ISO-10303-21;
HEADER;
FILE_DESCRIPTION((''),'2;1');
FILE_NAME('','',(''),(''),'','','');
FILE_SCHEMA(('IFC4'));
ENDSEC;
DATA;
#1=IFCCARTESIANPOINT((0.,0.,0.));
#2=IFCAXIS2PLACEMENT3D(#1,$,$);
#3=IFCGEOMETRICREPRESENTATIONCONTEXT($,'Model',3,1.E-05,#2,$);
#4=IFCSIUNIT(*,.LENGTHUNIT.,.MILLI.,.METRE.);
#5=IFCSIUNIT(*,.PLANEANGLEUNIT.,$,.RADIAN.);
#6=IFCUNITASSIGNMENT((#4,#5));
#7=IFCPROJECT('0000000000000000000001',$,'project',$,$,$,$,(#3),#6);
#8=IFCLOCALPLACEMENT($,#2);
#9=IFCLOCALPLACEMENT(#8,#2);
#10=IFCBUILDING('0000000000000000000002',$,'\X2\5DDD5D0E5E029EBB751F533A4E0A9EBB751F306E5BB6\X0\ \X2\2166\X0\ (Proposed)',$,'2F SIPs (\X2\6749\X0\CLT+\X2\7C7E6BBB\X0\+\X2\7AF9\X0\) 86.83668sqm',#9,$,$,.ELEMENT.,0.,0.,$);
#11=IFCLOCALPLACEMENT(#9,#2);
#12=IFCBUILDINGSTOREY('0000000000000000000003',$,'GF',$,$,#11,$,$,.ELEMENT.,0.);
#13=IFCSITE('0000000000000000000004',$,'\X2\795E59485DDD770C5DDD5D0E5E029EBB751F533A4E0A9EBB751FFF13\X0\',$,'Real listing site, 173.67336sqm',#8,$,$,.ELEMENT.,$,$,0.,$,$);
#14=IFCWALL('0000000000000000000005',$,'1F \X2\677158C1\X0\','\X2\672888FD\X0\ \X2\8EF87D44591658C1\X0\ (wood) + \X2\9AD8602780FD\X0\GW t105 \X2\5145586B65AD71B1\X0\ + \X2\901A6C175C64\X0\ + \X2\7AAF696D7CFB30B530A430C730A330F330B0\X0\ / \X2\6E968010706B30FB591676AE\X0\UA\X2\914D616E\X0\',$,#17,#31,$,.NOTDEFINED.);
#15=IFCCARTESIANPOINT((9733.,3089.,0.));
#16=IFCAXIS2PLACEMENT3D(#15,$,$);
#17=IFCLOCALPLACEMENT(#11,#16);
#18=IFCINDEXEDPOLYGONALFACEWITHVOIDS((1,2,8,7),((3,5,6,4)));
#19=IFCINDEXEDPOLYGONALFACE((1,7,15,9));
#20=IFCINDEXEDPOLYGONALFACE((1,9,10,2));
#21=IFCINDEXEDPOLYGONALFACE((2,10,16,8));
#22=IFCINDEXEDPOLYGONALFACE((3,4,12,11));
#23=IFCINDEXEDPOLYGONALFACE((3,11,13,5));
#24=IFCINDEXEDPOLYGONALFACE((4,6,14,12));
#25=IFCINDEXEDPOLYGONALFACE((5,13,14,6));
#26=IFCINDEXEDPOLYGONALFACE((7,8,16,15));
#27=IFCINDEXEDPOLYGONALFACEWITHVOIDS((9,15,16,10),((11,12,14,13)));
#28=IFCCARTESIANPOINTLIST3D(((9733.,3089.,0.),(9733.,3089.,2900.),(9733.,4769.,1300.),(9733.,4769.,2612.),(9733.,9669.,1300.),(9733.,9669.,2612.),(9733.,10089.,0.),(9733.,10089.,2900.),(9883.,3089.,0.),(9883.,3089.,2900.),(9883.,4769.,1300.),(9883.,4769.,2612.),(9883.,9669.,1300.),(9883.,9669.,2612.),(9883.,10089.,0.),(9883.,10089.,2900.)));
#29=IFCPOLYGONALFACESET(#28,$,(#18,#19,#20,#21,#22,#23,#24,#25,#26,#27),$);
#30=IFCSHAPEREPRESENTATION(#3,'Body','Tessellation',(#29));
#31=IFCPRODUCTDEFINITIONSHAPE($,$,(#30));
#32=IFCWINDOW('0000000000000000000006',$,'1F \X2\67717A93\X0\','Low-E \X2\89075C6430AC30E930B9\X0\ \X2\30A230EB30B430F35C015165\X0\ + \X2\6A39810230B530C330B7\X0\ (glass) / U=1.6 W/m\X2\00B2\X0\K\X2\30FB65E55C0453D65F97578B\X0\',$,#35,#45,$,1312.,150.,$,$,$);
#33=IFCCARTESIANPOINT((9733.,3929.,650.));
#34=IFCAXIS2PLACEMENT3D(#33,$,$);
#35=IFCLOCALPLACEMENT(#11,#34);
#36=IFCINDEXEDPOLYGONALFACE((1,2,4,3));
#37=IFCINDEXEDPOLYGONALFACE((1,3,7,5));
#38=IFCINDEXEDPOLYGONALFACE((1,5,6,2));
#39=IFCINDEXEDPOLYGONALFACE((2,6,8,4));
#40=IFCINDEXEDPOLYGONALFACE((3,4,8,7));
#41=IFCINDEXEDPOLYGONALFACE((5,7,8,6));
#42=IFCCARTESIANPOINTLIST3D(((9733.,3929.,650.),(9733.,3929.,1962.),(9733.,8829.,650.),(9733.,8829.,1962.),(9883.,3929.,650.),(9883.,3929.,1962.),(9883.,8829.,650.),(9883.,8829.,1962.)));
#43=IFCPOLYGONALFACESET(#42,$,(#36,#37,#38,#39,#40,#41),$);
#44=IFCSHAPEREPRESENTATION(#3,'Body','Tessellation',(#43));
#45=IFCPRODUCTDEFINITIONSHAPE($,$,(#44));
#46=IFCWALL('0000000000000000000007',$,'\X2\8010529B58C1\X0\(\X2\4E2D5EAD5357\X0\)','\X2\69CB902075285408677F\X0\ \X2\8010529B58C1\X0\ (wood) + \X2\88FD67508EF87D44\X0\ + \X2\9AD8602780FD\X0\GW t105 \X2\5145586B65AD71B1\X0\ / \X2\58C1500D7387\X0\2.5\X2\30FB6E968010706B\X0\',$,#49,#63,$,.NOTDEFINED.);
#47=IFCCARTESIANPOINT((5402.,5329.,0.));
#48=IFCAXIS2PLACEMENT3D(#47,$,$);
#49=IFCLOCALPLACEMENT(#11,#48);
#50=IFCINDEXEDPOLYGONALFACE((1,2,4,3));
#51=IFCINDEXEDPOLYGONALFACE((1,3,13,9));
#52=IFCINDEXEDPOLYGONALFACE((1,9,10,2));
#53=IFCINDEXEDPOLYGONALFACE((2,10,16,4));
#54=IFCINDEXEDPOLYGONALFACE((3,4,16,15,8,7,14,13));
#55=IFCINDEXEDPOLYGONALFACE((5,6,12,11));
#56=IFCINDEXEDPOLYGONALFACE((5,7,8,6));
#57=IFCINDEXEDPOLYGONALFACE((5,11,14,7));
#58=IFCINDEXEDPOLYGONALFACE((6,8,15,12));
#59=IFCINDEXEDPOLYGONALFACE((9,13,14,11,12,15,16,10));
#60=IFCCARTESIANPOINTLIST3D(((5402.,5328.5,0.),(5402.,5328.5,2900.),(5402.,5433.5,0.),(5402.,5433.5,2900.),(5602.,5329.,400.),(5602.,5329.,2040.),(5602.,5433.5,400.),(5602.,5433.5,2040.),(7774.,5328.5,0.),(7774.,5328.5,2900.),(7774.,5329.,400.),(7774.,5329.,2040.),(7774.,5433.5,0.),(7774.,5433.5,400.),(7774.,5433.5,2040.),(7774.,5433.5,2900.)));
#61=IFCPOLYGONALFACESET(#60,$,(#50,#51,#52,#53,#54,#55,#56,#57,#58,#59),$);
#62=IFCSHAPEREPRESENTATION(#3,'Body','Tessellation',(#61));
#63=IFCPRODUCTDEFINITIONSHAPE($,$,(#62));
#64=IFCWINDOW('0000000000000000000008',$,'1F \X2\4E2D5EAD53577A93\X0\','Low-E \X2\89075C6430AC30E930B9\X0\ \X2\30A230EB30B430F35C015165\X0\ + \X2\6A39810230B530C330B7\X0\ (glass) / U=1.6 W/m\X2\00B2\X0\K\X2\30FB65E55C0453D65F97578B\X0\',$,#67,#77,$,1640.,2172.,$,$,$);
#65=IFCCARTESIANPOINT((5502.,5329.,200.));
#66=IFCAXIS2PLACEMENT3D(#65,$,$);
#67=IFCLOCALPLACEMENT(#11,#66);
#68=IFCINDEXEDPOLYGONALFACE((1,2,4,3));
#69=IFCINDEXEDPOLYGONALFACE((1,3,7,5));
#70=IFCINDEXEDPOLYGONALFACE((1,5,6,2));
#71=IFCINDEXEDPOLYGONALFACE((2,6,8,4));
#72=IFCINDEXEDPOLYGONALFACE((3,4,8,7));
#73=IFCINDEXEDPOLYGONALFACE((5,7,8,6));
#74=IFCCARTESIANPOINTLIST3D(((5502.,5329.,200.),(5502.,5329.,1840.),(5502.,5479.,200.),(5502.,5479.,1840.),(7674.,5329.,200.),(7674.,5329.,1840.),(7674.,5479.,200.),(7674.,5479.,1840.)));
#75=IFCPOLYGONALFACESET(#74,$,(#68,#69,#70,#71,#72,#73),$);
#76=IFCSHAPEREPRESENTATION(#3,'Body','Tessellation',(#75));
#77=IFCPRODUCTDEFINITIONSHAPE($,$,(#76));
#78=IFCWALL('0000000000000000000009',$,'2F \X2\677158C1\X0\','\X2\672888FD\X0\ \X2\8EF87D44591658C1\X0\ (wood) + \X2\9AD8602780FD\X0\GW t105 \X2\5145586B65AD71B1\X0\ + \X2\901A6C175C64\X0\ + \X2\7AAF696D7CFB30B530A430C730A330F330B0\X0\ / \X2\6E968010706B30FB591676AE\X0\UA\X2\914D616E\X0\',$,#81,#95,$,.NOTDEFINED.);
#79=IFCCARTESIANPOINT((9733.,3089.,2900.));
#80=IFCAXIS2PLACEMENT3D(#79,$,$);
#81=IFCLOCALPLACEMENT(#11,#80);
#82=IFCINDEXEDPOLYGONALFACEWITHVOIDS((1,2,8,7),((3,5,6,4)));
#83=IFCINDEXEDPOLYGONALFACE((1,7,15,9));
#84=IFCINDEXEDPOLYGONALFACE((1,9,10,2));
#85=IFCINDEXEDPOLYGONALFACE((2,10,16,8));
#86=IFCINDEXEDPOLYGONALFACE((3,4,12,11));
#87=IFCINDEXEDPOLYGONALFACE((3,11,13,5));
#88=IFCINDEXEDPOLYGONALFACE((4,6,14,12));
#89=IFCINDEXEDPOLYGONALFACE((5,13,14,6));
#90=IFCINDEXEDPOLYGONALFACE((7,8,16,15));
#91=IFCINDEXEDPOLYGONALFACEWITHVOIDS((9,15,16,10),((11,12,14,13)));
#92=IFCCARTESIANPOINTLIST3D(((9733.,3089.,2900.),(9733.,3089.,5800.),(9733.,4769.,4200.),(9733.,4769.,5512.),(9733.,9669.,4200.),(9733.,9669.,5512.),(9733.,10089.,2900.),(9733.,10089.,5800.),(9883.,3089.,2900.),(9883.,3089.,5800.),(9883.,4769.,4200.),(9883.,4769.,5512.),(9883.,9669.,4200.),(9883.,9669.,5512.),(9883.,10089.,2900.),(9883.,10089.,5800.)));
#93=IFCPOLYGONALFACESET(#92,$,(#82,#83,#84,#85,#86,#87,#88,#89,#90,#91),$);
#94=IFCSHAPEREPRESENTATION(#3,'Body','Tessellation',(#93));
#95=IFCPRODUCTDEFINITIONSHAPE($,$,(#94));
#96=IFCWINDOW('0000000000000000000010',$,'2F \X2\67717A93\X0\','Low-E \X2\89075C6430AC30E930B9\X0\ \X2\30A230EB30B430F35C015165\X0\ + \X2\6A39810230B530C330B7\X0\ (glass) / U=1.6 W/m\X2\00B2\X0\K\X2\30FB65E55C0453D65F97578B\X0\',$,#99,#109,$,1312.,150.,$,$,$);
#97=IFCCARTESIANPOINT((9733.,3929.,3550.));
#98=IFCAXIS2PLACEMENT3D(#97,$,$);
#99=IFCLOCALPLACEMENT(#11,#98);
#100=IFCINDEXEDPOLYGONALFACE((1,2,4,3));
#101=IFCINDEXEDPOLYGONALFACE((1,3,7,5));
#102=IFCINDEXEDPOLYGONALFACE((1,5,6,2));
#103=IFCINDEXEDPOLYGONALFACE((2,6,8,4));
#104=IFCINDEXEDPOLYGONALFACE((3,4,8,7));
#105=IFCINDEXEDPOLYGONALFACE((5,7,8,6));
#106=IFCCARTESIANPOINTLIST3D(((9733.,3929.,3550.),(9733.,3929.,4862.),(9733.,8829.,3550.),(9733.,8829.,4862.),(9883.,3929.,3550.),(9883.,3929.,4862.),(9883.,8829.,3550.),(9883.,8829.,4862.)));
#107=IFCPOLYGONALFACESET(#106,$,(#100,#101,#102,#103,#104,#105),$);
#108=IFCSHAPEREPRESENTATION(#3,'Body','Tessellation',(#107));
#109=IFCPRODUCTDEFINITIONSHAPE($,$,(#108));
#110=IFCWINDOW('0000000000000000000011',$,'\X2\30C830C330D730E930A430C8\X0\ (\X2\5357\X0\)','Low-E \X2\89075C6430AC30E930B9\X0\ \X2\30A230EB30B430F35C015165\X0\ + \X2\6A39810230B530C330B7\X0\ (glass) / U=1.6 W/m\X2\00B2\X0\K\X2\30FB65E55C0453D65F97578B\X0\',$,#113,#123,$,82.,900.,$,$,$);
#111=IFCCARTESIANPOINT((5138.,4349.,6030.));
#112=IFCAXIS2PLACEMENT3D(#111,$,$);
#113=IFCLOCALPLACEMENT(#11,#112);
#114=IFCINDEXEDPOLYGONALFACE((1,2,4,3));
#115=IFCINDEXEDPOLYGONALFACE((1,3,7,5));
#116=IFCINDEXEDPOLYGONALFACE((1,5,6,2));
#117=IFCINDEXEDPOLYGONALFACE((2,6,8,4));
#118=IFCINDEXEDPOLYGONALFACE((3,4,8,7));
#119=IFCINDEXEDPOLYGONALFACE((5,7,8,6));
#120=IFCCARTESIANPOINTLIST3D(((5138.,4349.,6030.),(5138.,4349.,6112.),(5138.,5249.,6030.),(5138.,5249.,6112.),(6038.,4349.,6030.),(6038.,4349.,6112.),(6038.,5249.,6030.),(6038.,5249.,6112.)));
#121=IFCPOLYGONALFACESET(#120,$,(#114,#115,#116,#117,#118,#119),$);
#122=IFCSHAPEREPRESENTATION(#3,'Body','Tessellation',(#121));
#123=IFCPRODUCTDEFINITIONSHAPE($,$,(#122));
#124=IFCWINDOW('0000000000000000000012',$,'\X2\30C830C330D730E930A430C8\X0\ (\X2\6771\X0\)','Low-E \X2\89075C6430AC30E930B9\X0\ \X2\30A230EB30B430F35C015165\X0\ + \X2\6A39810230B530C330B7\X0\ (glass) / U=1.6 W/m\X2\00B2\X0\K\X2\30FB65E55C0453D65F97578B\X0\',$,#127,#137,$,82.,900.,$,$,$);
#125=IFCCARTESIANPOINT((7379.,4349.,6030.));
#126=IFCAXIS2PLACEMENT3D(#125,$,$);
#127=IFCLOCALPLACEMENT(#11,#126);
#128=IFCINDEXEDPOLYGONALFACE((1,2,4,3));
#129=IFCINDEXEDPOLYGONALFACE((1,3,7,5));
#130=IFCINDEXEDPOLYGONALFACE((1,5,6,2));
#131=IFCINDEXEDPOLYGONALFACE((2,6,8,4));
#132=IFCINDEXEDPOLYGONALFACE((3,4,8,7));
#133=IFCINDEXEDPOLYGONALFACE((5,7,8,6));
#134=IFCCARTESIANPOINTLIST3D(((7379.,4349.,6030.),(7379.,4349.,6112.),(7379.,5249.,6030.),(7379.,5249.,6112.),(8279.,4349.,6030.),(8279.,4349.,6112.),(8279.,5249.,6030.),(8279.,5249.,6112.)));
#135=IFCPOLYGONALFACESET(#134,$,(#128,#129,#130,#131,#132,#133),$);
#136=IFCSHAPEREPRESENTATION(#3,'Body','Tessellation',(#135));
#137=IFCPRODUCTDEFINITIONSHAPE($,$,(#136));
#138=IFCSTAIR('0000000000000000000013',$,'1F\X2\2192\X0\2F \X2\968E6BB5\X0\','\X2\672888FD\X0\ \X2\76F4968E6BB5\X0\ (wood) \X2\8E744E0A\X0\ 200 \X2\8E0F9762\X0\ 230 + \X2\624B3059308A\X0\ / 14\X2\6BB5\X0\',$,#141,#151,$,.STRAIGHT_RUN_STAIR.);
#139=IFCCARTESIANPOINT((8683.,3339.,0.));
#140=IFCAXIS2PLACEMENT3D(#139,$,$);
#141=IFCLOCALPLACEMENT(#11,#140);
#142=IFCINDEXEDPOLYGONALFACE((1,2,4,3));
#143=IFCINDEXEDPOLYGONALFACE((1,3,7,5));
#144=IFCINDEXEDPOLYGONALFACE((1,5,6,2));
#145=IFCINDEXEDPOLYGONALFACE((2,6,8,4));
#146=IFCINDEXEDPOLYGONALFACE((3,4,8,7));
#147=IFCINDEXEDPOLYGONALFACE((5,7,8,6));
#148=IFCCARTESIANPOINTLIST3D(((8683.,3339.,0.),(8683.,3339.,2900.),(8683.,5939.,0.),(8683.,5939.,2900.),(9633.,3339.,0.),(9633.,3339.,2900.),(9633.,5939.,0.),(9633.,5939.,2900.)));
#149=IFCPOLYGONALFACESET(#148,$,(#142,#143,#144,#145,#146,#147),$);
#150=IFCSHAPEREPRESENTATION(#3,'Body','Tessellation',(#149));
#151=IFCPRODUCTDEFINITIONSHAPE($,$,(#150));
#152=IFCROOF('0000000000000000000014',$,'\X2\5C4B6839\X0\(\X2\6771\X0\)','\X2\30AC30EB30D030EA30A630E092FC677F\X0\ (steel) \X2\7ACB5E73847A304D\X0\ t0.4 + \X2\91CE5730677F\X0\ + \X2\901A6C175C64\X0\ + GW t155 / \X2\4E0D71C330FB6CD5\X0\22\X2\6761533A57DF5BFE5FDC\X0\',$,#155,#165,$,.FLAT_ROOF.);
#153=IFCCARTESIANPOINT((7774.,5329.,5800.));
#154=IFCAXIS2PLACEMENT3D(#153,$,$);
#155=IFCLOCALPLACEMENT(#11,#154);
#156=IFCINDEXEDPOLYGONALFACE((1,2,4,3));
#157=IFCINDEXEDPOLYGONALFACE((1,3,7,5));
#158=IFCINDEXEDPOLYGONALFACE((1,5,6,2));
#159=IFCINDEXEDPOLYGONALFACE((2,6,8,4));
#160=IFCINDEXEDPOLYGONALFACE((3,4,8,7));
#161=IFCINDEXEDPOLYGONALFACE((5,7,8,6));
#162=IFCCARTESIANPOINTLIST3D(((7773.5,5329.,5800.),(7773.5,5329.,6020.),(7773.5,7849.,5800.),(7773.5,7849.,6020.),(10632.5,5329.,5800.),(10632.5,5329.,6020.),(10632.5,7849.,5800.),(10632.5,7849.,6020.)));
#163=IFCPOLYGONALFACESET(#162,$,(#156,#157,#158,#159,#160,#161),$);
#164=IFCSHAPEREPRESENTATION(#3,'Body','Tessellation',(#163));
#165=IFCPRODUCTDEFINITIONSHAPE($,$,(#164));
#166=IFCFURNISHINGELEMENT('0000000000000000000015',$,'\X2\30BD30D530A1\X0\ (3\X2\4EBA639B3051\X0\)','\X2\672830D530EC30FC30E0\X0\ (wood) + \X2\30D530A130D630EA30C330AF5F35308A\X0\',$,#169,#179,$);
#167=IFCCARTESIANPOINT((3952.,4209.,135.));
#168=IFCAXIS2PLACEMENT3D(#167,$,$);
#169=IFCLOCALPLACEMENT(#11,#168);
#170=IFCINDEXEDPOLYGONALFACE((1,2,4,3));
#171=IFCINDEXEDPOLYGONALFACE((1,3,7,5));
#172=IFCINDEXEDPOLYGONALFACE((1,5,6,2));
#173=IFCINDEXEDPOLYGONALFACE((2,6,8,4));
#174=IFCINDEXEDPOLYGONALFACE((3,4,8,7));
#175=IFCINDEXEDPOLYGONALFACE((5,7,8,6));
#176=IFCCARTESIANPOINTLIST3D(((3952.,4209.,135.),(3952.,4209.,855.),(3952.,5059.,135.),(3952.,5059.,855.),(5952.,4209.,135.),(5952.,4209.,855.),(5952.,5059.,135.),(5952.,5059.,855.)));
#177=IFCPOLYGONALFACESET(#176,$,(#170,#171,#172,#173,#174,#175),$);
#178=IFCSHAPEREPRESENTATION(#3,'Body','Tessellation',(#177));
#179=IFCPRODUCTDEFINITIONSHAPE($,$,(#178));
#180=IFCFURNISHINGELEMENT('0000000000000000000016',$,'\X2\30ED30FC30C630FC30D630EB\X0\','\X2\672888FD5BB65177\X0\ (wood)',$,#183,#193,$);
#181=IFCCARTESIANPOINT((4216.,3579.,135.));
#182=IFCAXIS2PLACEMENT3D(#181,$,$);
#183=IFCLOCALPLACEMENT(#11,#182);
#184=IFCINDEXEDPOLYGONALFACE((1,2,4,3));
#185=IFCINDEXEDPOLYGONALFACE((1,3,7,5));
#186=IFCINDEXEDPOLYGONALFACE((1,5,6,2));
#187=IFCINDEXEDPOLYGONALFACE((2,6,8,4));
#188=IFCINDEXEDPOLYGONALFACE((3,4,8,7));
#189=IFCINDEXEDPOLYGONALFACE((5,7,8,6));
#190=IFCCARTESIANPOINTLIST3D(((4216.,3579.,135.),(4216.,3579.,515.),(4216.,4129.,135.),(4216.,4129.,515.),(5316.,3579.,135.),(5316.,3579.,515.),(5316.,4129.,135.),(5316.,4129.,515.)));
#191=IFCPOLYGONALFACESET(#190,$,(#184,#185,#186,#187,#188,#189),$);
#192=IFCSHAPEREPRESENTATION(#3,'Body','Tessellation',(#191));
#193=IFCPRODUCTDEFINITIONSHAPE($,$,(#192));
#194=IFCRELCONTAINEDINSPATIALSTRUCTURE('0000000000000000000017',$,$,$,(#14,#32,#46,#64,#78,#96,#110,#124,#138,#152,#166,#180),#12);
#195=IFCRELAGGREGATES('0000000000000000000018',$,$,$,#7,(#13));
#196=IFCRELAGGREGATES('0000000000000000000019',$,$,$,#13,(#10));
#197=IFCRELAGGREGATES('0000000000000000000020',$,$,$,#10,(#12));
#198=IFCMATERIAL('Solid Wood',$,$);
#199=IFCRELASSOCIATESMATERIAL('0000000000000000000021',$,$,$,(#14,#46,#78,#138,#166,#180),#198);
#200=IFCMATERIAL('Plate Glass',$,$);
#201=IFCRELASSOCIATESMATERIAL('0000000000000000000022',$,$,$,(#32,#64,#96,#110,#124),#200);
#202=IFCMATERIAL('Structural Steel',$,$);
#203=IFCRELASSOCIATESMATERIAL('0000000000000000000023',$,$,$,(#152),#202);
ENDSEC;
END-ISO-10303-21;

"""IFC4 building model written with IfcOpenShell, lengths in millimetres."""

from ifc_helpers import new_model, si_unit, frame, frame_2d, origin, place, context, project, spatial, rectangle, extrude, material, element, fill, save


model = new_model("IFC4")

# Units and contexts
model_context = context("Model", 3, precision=1e-05, world=origin())
ifc_project = project(units=[si_unit("LENGTHUNIT", "METRE", prefix="MILLI"), si_unit("PLANEANGLEUNIT", "RADIAN")], contexts=[model_context])

# Site, building, storey
site_placement = place(None, origin())
site = spatial("IfcSite", under=ifc_project, at=site_placement, Name="神奈川県川崎市麻生区上麻生３", ObjectType="Real listing site, 173.67336sqm", CompositionType="ELEMENT", RefElevation=0.0)
building_placement = place(site_placement, origin())
building = spatial("IfcBuilding", under=site, at=building_placement, Name="川崎市麻生区上麻生の家 Ⅶ (Proposed)", ObjectType="2F SIPs (杉CLT+籾殻+竹) 86.83668sqm", CompositionType="ELEMENT", ElevationOfRefHeight=0.0, ElevationOfTerrain=0.0)
storey_placement = place(building_placement, origin())
storey = spatial("IfcBuildingStorey", under=building, at=storey_placement, Name="GF", CompositionType="ELEMENT", Elevation=0.0)

# Shared definitions
ifc_material_1 = material(Name="Solid Wood")

# Walls, openings, windows
wall_1_placement = place(storey_placement, frame((9733.0, 3089.0, 0.0)))
wall_1 = element("IfcWall", 1, at=wall_1_placement, inside=storey, material=ifc_material_1, Name="1F 東壁", Description="木製 軸組外壁 (wood) + 高性能GW t105 充填断熱 + 通気層 + 窯業系サイディング / 準耐火・外皮UA配慮", PredefinedType="NOTDEFINED", context=model_context, shape_type="SweptSolid", body=[
    extrude(rectangle(XDim=150.0, YDim=7000.0, at=frame_2d((75.0, 3500.0))), frame((9733.0, 3089.0, 0.0)), (0.0, 0.0, 1.0), 2900.0),
])
opening_1_placement = place(storey_placement, frame((9733.0, 3929.0, 650.0)))
opening_1 = element("IfcOpeningElement", 2, at=opening_1_placement, cuts=wall_1, PredefinedType="NOTDEFINED", context=model_context, shape_type="SweptSolid", body=[
    extrude(rectangle(XDim=150.0, YDim=4900.0, at=frame_2d((75.0, 2450.0))), frame((9733.0, 3929.0, 650.0)), (0.0, 0.0, 1.0), 1312.0),
])
ifc_material_2 = material(Name="Plate Glass")
window_1_placement = place(storey_placement, frame((9733.0, 3929.0, 650.0)))
window_1 = element("IfcWindow", 3, at=window_1_placement, inside=storey, material=ifc_material_2, Name="1F 東窓", Description="Low-E 複層ガラス アルゴン封入 + 樹脂サッシ (glass) / U=1.6 W/m²K・日射取得型", OverallHeight=1312.0, OverallWidth=150.0, context=model_context, shape_type="SweptSolid", body=[
    extrude(rectangle(XDim=150.0, YDim=4900.0, at=frame_2d((75.0, 2450.0))), frame((9733.0, 3929.0, 650.0)), (0.0, 0.0, 1.0), 1312.0),
])
fill(opening_1, window_1)
wall_2_placement = place(storey_placement, frame((5402.0, 5329.0, 0.0)))
wall_2 = element("IfcWall", 4, at=wall_2_placement, inside=storey, material=ifc_material_1, Name="耐力壁(中庭南)", Description="構造用合板 耐力壁 (wood) + 製材軸組 + 高性能GW t105 充填断熱 / 壁倍率2.5・準耐火", PredefinedType="NOTDEFINED", context=model_context, shape_type="SweptSolid", body=[
    extrude(rectangle(XDim=2372.0, YDim=105.0, at=frame_2d((1186.0, 52.0))), frame((5402.0, 5329.0, 0.0)), (0.0, 0.0, 1.0), 2900.0),
])
opening_2_placement = place(storey_placement, frame((5502.0, 5329.0, 200.0)))
opening_2 = element("IfcOpeningElement", 5, at=opening_2_placement, cuts=wall_2, PredefinedType="NOTDEFINED", context=model_context, shape_type="SweptSolid", body=[
    extrude(rectangle(XDim=2172.0, YDim=150.0, at=frame_2d((1086.0, 75.0))), frame((5502.0, 5329.0, 200.0)), (0.0, 0.0, 1.0), 1640.0),
])
window_2_placement = place(storey_placement, frame((5502.0, 5329.0, 200.0)))
window_2 = element("IfcWindow", 6, at=window_2_placement, inside=storey, material=ifc_material_2, Name="1F 中庭南窓", Description="Low-E 複層ガラス アルゴン封入 + 樹脂サッシ (glass) / U=1.6 W/m²K・日射取得型", OverallHeight=1640.0, OverallWidth=2172.0, context=model_context, shape_type="SweptSolid", body=[
    extrude(rectangle(XDim=2172.0, YDim=150.0, at=frame_2d((1086.0, 75.0))), frame((5502.0, 5329.0, 200.0)), (0.0, 0.0, 1.0), 1640.0),
])
fill(opening_2, window_2)

# Wall, opening, window
wall_3_placement = place(storey_placement, frame((9733.0, 3089.0, 2900.0)))
wall_3 = element("IfcWall", 7, at=wall_3_placement, inside=storey, material=ifc_material_1, Name="2F 東壁", Description="木製 軸組外壁 (wood) + 高性能GW t105 充填断熱 + 通気層 + 窯業系サイディング / 準耐火・外皮UA配慮", PredefinedType="NOTDEFINED", context=model_context, shape_type="SweptSolid", body=[
    extrude(rectangle(XDim=150.0, YDim=7000.0, at=frame_2d((75.0, 3500.0))), frame((9733.0, 3089.0, 2900.0)), (0.0, 0.0, 1.0), 2900.0),
])
opening_3_placement = place(storey_placement, frame((9733.0, 3929.0, 3550.0)))
opening_3 = element("IfcOpeningElement", 8, at=opening_3_placement, cuts=wall_3, PredefinedType="NOTDEFINED", context=model_context, shape_type="SweptSolid", body=[
    extrude(rectangle(XDim=150.0, YDim=4900.0, at=frame_2d((75.0, 2450.0))), frame((9733.0, 3929.0, 3550.0)), (0.0, 0.0, 1.0), 1312.0),
])
window_3_placement = place(storey_placement, frame((9733.0, 3929.0, 3550.0)))
window_3 = element("IfcWindow", 9, at=window_3_placement, inside=storey, material=ifc_material_2, Name="2F 東窓", Description="Low-E 複層ガラス アルゴン封入 + 樹脂サッシ (glass) / U=1.6 W/m²K・日射取得型", OverallHeight=1312.0, OverallWidth=150.0, context=model_context, shape_type="SweptSolid", body=[
    extrude(rectangle(XDim=150.0, YDim=4900.0, at=frame_2d((75.0, 2450.0))), frame((9733.0, 3929.0, 3550.0)), (0.0, 0.0, 1.0), 1312.0),
])
fill(opening_3, window_3)

# Windows
window_4_placement = place(storey_placement, frame((5138.0, 4349.0, 6030.0)))
element("IfcWindow", 10, at=window_4_placement, inside=storey, material=ifc_material_2, Name="トップライト (南)", Description="Low-E 複層ガラス アルゴン封入 + 樹脂サッシ (glass) / U=1.6 W/m²K・日射取得型", OverallHeight=82.0, OverallWidth=900.0, context=model_context, shape_type="SweptSolid", body=[
    extrude(rectangle(XDim=900.0, YDim=900.0, at=frame_2d((450.0, 450.0))), frame((5138.0, 4349.0, 6030.0)), (0.0, 0.0, 1.0), 82.0),
])
window_5_placement = place(storey_placement, frame((7379.0, 4349.0, 6030.0)))
element("IfcWindow", 11, at=window_5_placement, inside=storey, material=ifc_material_2, Name="トップライト (東)", Description="Low-E 複層ガラス アルゴン封入 + 樹脂サッシ (glass) / U=1.6 W/m²K・日射取得型", OverallHeight=82.0, OverallWidth=900.0, context=model_context, shape_type="SweptSolid", body=[
    extrude(rectangle(XDim=900.0, YDim=900.0, at=frame_2d((450.0, 450.0))), frame((7379.0, 4349.0, 6030.0)), (0.0, 0.0, 1.0), 82.0),
])

# Stair
stair_placement = place(storey_placement, frame((8683.0, 3339.0, 0.0)))
element("IfcStair", 12, at=stair_placement, inside=storey, material=ifc_material_1, Name="1F→2F 階段", Description="木製 直階段 (wood) 蹴上 200 踏面 230 + 手すり / 14段", PredefinedType="STRAIGHT_RUN_STAIR", context=model_context, shape_type="SweptSolid", body=[
    extrude(rectangle(XDim=950.0, YDim=2600.0, at=frame_2d((475.0, 1300.0))), frame((8683.0, 3339.0, 0.0)), (0.0, 0.0, 1.0), 2900.0),
])

# Roof
ifc_material_3 = material(Name="Structural Steel")
roof_placement = place(storey_placement, frame((7774.0, 5329.0, 5800.0)))
element("IfcRoof", 13, at=roof_placement, inside=storey, material=ifc_material_3, Name="屋根(東)", Description="ガルバリウム鋼板 (steel) 立平葺き t0.4 + 野地板 + 通気層 + GW t155 / 不燃・法22条区域対応", PredefinedType="FLAT_ROOF", context=model_context, shape_type="SweptSolid", body=[
    extrude(rectangle(XDim=2859.0, YDim=2520.0, at=frame_2d((1429.0, 1260.0))), frame((7774.0, 5329.0, 5800.0)), (0.0, 0.0, 1.0), 220.0),
])

# Furnishing elements
furnishing_1_placement = place(storey_placement, frame((3952.0, 4209.0, 135.0)))
element("IfcFurnishingElement", 14, at=furnishing_1_placement, inside=storey, material=ifc_material_1, Name="ソファ (3人掛け)", Description="木フレーム (wood) + ファブリック張り", context=model_context, shape_type="SweptSolid", body=[
    extrude(rectangle(XDim=2000.0, YDim=850.0, at=frame_2d((1000.0, 425.0))), frame((3952.0, 4209.0, 135.0)), (0.0, 0.0, 1.0), 720.0),
])
furnishing_2_placement = place(storey_placement, frame((4216.0, 3579.0, 135.0)))
element("IfcFurnishingElement", 15, at=furnishing_2_placement, inside=storey, material=ifc_material_1, Name="ローテーブル", Description="木製家具 (wood)", context=model_context, shape_type="SweptSolid", body=[
    extrude(rectangle(XDim=1100.0, YDim=550.0, at=frame_2d((550.0, 275.0))), frame((4216.0, 3579.0, 135.0)), (0.0, 0.0, 1.0), 380.0),
])

save(model, "model.ifc")
